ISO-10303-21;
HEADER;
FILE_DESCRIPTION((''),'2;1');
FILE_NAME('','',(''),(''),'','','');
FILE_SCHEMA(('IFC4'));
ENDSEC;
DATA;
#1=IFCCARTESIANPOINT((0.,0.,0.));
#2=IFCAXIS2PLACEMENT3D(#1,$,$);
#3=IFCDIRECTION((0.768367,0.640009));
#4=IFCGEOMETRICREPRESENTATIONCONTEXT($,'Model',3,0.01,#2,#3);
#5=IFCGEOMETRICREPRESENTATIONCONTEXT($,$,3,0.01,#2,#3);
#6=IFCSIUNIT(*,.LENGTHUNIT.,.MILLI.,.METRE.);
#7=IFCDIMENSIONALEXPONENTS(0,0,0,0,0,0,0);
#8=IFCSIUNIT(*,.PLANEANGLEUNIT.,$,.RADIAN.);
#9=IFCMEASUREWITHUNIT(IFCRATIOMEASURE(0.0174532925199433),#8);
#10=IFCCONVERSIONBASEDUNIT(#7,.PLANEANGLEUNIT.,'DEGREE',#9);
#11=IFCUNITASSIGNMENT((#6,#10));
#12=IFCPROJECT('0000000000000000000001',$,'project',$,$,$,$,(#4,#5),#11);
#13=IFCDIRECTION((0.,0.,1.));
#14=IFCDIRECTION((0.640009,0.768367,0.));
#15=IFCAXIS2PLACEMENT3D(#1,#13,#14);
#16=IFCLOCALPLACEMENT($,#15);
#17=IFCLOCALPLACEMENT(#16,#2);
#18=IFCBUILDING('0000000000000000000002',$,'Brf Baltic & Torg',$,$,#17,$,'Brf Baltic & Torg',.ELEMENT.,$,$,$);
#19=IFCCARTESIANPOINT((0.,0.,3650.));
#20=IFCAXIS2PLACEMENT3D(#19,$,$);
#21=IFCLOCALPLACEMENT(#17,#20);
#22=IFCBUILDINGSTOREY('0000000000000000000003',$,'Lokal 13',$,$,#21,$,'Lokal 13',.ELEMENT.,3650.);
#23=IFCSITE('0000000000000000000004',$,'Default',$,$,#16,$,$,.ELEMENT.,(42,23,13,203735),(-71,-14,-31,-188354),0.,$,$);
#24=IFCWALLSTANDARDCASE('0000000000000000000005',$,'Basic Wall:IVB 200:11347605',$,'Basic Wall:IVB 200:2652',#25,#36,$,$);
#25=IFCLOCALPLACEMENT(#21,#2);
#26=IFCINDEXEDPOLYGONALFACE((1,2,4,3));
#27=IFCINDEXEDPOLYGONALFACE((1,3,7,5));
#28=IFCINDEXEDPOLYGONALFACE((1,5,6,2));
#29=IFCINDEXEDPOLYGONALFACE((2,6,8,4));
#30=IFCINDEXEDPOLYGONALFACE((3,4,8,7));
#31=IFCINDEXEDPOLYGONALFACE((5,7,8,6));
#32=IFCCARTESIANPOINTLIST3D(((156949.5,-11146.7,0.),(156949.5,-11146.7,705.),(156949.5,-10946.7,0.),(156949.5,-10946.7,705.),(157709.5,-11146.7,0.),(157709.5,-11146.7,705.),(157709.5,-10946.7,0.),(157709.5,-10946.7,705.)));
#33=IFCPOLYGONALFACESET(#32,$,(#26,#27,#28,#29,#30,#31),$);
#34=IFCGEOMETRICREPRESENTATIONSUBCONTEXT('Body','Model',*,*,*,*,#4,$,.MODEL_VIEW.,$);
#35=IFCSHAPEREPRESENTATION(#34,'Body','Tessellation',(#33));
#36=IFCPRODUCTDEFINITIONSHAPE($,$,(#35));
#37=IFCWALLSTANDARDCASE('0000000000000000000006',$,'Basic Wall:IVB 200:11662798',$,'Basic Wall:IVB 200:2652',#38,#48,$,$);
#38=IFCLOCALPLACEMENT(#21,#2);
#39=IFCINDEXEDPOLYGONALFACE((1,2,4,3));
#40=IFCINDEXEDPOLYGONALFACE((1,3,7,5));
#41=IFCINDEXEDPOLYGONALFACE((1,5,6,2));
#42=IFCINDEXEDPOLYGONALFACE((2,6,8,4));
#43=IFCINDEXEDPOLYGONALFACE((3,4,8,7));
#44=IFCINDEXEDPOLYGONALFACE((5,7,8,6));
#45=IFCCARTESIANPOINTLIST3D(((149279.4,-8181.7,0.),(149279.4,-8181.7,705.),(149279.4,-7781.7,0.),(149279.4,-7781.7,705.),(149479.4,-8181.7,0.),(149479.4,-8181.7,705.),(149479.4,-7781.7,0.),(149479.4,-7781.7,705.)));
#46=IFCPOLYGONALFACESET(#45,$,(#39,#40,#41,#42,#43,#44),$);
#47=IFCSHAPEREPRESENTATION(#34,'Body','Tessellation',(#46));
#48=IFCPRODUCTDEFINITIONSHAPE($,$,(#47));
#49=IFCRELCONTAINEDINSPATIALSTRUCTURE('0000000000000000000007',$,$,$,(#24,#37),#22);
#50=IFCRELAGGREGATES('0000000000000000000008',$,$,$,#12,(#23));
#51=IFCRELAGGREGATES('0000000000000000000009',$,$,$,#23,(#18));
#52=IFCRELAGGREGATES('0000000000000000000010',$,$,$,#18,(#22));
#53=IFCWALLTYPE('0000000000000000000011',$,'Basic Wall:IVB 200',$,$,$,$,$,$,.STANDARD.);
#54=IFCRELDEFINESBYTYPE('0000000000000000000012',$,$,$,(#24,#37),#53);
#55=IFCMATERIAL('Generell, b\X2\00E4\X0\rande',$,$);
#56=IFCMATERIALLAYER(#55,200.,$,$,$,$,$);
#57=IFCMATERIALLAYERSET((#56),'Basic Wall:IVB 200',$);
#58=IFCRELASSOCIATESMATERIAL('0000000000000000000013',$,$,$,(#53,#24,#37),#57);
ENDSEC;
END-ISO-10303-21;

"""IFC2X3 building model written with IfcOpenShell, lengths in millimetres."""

from ifc_helpers import new_model, entity, si_unit, converted_unit, direction, frame, frame_2d, origin, place, context, subcontext, project, spatial, polyline, rectangle, extrude, clip, halfspace, bounded_halfspace, material, layer, layer_set, layer_usage, type_object, element, save


model = new_model("IFC2X3")

# Units and contexts
model_context = context("Model", 3, precision=0.01, world=origin(), true_north=direction((0.768367, 0.640009)))
context_of_model = context(None, 3, precision=0.01, world=origin(), true_north=direction((0.768367, 0.640009)))
body_context = subcontext(model_context, "Body", "Model", "MODEL_VIEW")
ifc_project = project(units=[si_unit("LENGTHUNIT", "METRE", prefix="MILLI"), converted_unit("PLANEANGLEUNIT", "DEGREE", entity("IfcRatioMeasure", 0.0174532925199433), si_unit("PLANEANGLEUNIT", "RADIAN"), dimensions=[0, 0, 0, 0, 0, 0, 0])], contexts=[model_context, context_of_model])

# Site, building, storey
site_placement = place(None, frame((0.0, 0.0, 0.0), z_axis=(0.0, 0.0, 1.0), x_axis=(0.640009, 0.768367, 0.0)))
site = spatial("IfcSite", under=ifc_project, at=site_placement, Name="Default", CompositionType="ELEMENT", RefLatitude=(42, 23, 13, 203735), RefLongitude=(-71, -14, -31, -188354), RefElevation=0.0)
building_placement = place(site_placement, origin())
building = spatial("IfcBuilding", under=site, at=building_placement, Name="Brf Baltic & Torg", LongName="Brf Baltic & Torg", CompositionType="ELEMENT")
storey_placement = place(building_placement, frame((0.0, 0.0, 3650.0)))
storey = spatial("IfcBuildingStorey", under=building, at=storey_placement, Name="Lokal 13", LongName="Lokal 13", CompositionType="ELEMENT", Elevation=3650.0)

# Shared definitions
ifc_material_1 = material(Name="Generell, bärande")
ifc_layer = layer(ifc_material_1, 200.0)
ifc_layer_set = layer_set([ifc_layer], Name="Basic Wall:IVB 200")
wall_type = type_object("IfcWallType", Name="Basic Wall:IVB 200", PredefinedType="STANDARD", material=ifc_layer_set)

# Wall
ifc_layer_usage_1 = layer_usage(ifc_layer_set, "AXIS2", "NEGATIVE", 100.0)
wall_1_placement = place(storey_placement, frame((156949.5, -11046.7, 0.0)))
element("IfcWallStandardCase", 1, at=wall_1_placement, inside=storey, type_object=wall_type, material=ifc_layer_usage_1, Name="Basic Wall:IVB 200:11347605", ObjectType="Basic Wall:IVB 200:2652", context=body_context, shape_type="Clipping", body=[
    clip(clip(extrude(rectangle(XDim=760.0, YDim=200.0, at=frame_2d((380.0, 0.0), x_axis=(-1.0, 0.0))), origin(), (0.0, 0.0, 1.0), 705.0), bounded_halfspace(frame((0.0, -100.0, 705.0), z_axis=(0.0, 0.0, -1.0), x_axis=(0.0, 1.0, 0.0)), True, frame((0.0, -100.0, 705.0)), polyline([(0.0, 0.0), (760.0, 0.0), (760.0, 200.0), (0.0, 200.0), (0.0, 0.0)]))), halfspace(frame((0.0, 0.0, -2000.0)), True)),
])

# Wall
ifc_layer_usage_2 = layer_usage(ifc_layer_set, "AXIS2", "NEGATIVE", 100.0)
wall_2_placement = place(storey_placement, frame((149379.4, -8181.7, 0.0), z_axis=(0.0, 0.0, 1.0), x_axis=(0.0, 1.0, 0.0)))
element("IfcWallStandardCase", 2, at=wall_2_placement, inside=storey, type_object=wall_type, material=ifc_layer_usage_2, Name="Basic Wall:IVB 200:11662798", ObjectType="Basic Wall:IVB 200:2652", context=body_context, shape_type="Clipping", body=[
    clip(extrude(rectangle(XDim=400.0, YDim=200.0, at=frame_2d((200.0, 0.0), x_axis=(-1.0, 0.0))), origin(), (0.0, 0.0, 1.0), 705.0), halfspace(frame((0.0, 0.0, -2000.0)), True)),
])

save(model, "model.ifc")
